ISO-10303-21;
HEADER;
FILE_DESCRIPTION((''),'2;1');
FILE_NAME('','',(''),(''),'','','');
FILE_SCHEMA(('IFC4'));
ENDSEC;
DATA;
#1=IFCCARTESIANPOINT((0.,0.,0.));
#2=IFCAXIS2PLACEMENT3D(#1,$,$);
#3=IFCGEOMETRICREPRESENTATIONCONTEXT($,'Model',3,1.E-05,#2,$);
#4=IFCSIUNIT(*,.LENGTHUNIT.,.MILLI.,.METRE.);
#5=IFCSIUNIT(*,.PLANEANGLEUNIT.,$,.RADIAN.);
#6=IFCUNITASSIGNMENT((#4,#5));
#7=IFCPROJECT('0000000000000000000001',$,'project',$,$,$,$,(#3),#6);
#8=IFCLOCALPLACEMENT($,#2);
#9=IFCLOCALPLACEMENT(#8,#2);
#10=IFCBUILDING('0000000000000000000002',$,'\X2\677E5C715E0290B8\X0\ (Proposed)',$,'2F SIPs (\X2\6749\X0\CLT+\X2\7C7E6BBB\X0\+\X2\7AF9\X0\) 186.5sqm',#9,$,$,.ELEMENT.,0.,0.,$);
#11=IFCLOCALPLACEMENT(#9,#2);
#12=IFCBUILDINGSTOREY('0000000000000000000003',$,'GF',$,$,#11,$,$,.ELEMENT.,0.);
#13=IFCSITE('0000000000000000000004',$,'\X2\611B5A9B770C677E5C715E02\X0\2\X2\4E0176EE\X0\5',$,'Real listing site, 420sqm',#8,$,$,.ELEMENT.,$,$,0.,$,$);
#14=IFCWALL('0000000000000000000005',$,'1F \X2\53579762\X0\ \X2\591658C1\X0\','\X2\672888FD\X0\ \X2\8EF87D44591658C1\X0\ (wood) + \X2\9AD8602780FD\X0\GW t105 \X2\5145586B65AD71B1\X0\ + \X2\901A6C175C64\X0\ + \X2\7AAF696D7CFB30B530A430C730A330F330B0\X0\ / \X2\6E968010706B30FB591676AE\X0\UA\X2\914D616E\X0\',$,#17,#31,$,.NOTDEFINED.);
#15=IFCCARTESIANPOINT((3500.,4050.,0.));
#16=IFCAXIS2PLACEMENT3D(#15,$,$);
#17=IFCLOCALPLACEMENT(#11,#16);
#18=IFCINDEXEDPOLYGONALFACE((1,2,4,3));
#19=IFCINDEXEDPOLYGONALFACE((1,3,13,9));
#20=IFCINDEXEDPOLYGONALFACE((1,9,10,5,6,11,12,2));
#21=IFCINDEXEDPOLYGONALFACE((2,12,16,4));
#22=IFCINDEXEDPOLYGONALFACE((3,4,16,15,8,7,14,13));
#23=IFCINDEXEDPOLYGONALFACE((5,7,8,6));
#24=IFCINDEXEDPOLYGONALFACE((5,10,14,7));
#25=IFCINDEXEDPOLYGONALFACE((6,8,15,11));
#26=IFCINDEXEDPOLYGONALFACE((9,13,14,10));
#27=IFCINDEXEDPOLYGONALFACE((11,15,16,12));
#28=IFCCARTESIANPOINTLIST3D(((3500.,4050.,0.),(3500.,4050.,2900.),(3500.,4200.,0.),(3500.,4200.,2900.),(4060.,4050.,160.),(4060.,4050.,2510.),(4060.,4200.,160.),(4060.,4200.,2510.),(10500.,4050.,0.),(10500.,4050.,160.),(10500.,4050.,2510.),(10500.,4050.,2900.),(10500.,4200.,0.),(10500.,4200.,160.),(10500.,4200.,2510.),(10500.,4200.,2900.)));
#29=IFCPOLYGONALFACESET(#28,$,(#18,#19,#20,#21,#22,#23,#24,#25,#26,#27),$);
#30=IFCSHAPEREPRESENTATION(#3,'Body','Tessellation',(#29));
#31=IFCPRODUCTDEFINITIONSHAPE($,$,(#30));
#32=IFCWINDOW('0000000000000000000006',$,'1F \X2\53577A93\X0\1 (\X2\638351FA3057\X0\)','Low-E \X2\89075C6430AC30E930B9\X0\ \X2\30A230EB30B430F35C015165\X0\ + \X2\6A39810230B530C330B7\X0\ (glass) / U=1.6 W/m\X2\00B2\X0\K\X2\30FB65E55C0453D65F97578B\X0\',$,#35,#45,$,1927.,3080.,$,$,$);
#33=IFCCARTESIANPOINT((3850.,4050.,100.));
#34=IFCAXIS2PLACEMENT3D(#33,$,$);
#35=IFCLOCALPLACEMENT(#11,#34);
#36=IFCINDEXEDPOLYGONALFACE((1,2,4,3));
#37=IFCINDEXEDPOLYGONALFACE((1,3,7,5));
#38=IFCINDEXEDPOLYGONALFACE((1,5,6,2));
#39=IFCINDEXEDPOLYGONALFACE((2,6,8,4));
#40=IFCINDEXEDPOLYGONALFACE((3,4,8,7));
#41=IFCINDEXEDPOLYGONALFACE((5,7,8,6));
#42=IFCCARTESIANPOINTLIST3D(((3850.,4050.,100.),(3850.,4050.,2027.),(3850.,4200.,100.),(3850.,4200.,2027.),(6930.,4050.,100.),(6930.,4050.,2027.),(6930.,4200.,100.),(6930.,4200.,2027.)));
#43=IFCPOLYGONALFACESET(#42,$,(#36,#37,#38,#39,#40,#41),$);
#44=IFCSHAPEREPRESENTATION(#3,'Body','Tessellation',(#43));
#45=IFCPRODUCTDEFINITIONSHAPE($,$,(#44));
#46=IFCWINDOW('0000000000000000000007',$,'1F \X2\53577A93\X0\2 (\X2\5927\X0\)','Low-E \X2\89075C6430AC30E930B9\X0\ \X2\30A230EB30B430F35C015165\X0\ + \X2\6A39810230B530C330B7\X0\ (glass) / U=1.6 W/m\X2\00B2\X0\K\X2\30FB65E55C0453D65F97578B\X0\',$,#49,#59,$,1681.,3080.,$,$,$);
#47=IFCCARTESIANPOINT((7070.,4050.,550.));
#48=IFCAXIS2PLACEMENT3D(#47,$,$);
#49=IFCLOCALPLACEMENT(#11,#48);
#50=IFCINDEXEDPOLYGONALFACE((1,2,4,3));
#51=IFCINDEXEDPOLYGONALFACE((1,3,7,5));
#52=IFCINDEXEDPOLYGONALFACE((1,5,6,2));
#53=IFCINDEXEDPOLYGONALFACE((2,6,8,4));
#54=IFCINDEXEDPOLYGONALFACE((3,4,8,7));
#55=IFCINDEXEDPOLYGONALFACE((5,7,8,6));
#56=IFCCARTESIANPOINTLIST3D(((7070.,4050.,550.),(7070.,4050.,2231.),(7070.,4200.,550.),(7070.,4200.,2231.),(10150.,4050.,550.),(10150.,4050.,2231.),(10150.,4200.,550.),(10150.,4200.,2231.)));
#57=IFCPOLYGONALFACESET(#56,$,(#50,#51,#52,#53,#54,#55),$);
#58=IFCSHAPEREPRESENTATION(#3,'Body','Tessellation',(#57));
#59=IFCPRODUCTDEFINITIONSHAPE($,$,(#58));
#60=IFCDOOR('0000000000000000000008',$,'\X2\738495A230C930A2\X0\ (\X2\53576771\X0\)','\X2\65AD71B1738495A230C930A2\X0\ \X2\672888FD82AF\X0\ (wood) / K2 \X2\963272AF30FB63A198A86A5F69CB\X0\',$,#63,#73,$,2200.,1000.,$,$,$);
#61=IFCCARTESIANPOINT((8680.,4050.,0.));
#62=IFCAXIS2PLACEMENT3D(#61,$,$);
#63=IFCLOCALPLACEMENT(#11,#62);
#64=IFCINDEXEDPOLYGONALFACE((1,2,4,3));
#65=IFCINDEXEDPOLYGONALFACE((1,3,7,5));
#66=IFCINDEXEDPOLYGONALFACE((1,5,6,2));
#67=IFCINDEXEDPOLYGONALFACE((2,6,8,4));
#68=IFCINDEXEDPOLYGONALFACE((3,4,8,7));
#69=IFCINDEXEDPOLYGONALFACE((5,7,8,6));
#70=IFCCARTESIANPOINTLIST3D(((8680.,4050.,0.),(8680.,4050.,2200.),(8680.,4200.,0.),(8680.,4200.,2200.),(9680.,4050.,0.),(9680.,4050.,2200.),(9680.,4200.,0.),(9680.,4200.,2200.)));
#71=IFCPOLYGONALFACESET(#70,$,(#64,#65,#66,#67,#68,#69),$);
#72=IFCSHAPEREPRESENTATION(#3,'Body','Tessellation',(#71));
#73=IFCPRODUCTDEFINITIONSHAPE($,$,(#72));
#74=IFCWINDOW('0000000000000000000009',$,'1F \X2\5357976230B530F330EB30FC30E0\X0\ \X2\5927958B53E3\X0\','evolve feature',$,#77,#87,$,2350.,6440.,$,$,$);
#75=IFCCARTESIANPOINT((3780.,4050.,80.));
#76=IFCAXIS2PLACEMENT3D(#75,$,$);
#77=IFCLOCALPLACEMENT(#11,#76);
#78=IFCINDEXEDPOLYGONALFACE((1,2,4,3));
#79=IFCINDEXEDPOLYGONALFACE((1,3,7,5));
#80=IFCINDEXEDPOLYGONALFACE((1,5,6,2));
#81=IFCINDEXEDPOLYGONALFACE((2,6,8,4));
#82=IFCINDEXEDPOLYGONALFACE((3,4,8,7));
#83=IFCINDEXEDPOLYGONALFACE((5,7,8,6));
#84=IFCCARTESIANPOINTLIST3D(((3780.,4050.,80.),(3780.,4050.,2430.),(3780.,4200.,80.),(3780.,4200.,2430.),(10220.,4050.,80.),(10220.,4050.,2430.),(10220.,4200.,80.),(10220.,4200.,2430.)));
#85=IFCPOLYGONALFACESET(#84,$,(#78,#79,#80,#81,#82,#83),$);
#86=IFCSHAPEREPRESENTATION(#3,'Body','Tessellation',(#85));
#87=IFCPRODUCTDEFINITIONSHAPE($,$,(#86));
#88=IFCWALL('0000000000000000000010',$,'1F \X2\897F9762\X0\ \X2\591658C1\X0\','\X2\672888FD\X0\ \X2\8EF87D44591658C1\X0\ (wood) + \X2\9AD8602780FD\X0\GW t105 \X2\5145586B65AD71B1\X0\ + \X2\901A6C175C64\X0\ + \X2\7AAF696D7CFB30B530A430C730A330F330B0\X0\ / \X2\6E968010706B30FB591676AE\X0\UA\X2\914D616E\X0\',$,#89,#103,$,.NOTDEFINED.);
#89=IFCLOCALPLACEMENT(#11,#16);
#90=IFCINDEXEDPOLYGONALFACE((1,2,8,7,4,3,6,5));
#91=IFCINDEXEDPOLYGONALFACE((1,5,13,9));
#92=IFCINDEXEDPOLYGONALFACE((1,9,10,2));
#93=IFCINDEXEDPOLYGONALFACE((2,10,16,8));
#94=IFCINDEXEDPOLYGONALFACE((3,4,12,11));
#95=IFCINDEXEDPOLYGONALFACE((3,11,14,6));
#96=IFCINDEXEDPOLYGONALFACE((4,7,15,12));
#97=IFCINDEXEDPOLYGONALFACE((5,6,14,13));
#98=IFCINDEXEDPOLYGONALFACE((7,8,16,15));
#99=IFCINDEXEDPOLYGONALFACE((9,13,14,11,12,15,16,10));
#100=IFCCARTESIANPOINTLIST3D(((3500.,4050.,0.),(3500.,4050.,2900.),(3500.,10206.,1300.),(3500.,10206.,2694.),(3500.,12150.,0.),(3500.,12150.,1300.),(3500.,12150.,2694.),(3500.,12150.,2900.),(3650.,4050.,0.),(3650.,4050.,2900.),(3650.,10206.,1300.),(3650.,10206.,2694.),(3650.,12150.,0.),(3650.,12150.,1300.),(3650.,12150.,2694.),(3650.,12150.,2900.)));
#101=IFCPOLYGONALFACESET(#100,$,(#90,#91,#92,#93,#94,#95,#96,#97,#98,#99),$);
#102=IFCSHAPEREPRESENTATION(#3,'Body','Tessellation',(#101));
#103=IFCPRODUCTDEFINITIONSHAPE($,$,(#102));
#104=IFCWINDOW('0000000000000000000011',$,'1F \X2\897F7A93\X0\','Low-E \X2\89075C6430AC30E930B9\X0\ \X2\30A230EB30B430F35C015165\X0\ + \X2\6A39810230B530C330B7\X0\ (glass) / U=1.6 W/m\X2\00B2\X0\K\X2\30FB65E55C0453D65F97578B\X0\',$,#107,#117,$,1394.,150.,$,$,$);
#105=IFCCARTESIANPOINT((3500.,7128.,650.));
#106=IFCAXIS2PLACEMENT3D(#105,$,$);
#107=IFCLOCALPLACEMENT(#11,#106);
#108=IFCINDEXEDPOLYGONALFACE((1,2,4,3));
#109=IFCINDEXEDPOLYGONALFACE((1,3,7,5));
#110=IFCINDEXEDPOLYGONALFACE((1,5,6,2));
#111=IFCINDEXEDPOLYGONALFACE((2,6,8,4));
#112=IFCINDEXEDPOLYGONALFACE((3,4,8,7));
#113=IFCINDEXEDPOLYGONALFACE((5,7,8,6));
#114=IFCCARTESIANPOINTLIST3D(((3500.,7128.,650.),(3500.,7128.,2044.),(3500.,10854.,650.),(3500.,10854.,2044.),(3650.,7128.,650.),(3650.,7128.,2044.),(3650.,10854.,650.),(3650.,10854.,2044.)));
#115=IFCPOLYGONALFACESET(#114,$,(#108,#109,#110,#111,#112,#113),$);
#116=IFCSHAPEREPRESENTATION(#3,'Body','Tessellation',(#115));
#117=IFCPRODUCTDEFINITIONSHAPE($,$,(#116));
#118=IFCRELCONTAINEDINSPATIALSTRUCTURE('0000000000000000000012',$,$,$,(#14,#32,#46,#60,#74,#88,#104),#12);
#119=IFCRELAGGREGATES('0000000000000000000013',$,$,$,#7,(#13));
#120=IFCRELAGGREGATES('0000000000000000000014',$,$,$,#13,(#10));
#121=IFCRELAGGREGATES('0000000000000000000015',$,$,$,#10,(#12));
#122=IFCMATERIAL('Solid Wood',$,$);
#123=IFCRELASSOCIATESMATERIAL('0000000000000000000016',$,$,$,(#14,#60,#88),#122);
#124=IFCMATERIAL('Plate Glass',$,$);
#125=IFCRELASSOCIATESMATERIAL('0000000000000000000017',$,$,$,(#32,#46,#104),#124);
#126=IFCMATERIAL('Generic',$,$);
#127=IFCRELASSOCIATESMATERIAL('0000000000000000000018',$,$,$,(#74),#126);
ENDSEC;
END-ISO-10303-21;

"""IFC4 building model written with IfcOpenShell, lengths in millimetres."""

from ifc_helpers import new_model, si_unit, frame, frame_2d, origin, place, context, project, spatial, rectangle, extrude, material, element, fill, save


model = new_model("IFC4")

# Units and contexts
model_context = context("Model", 3, precision=1e-05, world=origin())
ifc_project = project(units=[si_unit("LENGTHUNIT", "METRE", prefix="MILLI"), si_unit("PLANEANGLEUNIT", "RADIAN")], contexts=[model_context])

# Site, building, storey
site_placement = place(None, origin())
site = spatial("IfcSite", under=ifc_project, at=site_placement, Name="愛媛県松山市2丁目5", ObjectType="Real listing site, 420sqm", CompositionType="ELEMENT", RefElevation=0.0)
building_placement = place(site_placement, origin())
building = spatial("IfcBuilding", under=site, at=building_placement, Name="松山市邸 (Proposed)", ObjectType="2F SIPs (杉CLT+籾殻+竹) 186.5sqm", CompositionType="ELEMENT", ElevationOfRefHeight=0.0, ElevationOfTerrain=0.0)
storey_placement = place(building_placement, origin())
storey = spatial("IfcBuildingStorey", under=building, at=storey_placement, Name="GF", CompositionType="ELEMENT", Elevation=0.0)

# Shared definitions
ifc_material_1 = material(Name="Solid Wood")
ifc_material_2 = material(Name="Generic")

# Wall, openings, windows, door
wall_1_placement = place(storey_placement, frame((3500.0, 4050.0, 0.0)))
wall_1 = element("IfcWall", 1, at=wall_1_placement, inside=storey, material=ifc_material_1, Name="1F 南面 外壁", Description="木製 軸組外壁 (wood) + 高性能GW t105 充填断熱 + 通気層 + 窯業系サイディング / 準耐火・外皮UA配慮", PredefinedType="NOTDEFINED", context=model_context, shape_type="SweptSolid", body=[
    extrude(rectangle(XDim=7000.0, YDim=150.0, at=frame_2d((3500.0, 75.0))), frame((3500.0, 4050.0, 0.0)), (0.0, 0.0, 1.0), 2900.0),
])
opening_1_placement = place(storey_placement, frame((3850.0, 4050.0, 100.0)))
opening_1 = element("IfcOpeningElement", 2, at=opening_1_placement, cuts=wall_1, PredefinedType="NOTDEFINED", context=model_context, shape_type="SweptSolid", body=[
    extrude(rectangle(XDim=3080.0, YDim=150.0, at=frame_2d((1540.0, 75.0))), frame((3850.0, 4050.0, 100.0)), (0.0, 0.0, 1.0), 1927.0),
])
opening_2_placement = place(storey_placement, frame((7070.0, 4050.0, 550.0)))
opening_2 = element("IfcOpeningElement", 3, at=opening_2_placement, cuts=wall_1, PredefinedType="NOTDEFINED", context=model_context, shape_type="SweptSolid", body=[
    extrude(rectangle(XDim=3080.0, YDim=150.0, at=frame_2d((1540.0, 75.0))), frame((7070.0, 4050.0, 550.0)), (0.0, 0.0, 1.0), 1681.0),
])
opening_3_placement = place(storey_placement, frame((8680.0, 4050.0, 0.0)))
opening_3 = element("IfcOpeningElement", 4, at=opening_3_placement, cuts=wall_1, PredefinedType="NOTDEFINED", context=model_context, shape_type="SweptSolid", body=[
    extrude(rectangle(XDim=1000.0, YDim=150.0, at=frame_2d((500.0, 75.0))), frame((8680.0, 4050.0, 0.0)), (0.0, 0.0, 1.0), 2200.0),
])
opening_4_placement = place(storey_placement, frame((3780.0, 4050.0, 80.0)))
opening_4 = element("IfcOpeningElement", 5, at=opening_4_placement, cuts=wall_1, PredefinedType="NOTDEFINED", context=model_context, shape_type="SweptSolid", body=[
    extrude(rectangle(XDim=6440.0, YDim=150.0, at=frame_2d((3220.0, 75.0))), frame((3780.0, 4050.0, 80.0)), (0.0, 0.0, 1.0), 2350.0),
])
ifc_material_3 = material(Name="Plate Glass")
window_1_placement = place(storey_placement, frame((3850.0, 4050.0, 100.0)))
window_1 = element("IfcWindow", 6, at=window_1_placement, inside=storey, material=ifc_material_3, Name="1F 南窓1 (掃出し)", Description="Low-E 複層ガラス アルゴン封入 + 樹脂サッシ (glass) / U=1.6 W/m²K・日射取得型", OverallHeight=1927.0, OverallWidth=3080.0, context=model_context, shape_type="SweptSolid", body=[
    extrude(rectangle(XDim=3080.0, YDim=150.0, at=frame_2d((1540.0, 75.0))), frame((3850.0, 4050.0, 100.0)), (0.0, 0.0, 1.0), 1927.0),
])
fill(opening_1, window_1)
window_2_placement = place(storey_placement, frame((7070.0, 4050.0, 550.0)))
window_2 = element("IfcWindow", 7, at=window_2_placement, inside=storey, material=ifc_material_3, Name="1F 南窓2 (大)", Description="Low-E 複層ガラス アルゴン封入 + 樹脂サッシ (glass) / U=1.6 W/m²K・日射取得型", OverallHeight=1681.0, OverallWidth=3080.0, context=model_context, shape_type="SweptSolid", body=[
    extrude(rectangle(XDim=3080.0, YDim=150.0, at=frame_2d((1540.0, 75.0))), frame((7070.0, 4050.0, 550.0)), (0.0, 0.0, 1.0), 1681.0),
])
fill(opening_2, window_2)
door_placement = place(storey_placement, frame((8680.0, 4050.0, 0.0)))
door = element("IfcDoor", 8, at=door_placement, inside=storey, material=ifc_material_1, Name="玄関ドア (南東)", Description="断熱玄関ドア 木製芯 (wood) / K2 防犯・採風機構", OverallHeight=2200.0, OverallWidth=1000.0, context=model_context, shape_type="SweptSolid", body=[
    extrude(rectangle(XDim=1000.0, YDim=150.0, at=frame_2d((500.0, 75.0))), frame((8680.0, 4050.0, 0.0)), (0.0, 0.0, 1.0), 2200.0),
])
fill(opening_3, door)
window_3_placement = place(storey_placement, frame((3780.0, 4050.0, 80.0)))
window_3 = element("IfcWindow", 9, at=window_3_placement, inside=storey, material=ifc_material_2, Name="1F 南面サンルーム 大開口", Description="evolve feature", OverallHeight=2350.0, OverallWidth=6440.0, context=model_context, shape_type="SweptSolid", body=[
    extrude(rectangle(XDim=6440.0, YDim=150.0, at=frame_2d((3220.0, 75.0))), frame((3780.0, 4050.0, 80.0)), (0.0, 0.0, 1.0), 2350.0),
])
fill(opening_4, window_3)

# Wall, opening, window
wall_2_placement = place(storey_placement, frame((3500.0, 4050.0, 0.0)))
wall_2 = element("IfcWall", 10, at=wall_2_placement, inside=storey, material=ifc_material_1, Name="1F 西面 外壁", Description="木製 軸組外壁 (wood) + 高性能GW t105 充填断熱 + 通気層 + 窯業系サイディング / 準耐火・外皮UA配慮", PredefinedType="NOTDEFINED", context=model_context, shape_type="SweptSolid", body=[
    extrude(rectangle(XDim=150.0, YDim=8100.0, at=frame_2d((75.0, 4050.0))), frame((3500.0, 4050.0, 0.0)), (0.0, 0.0, 1.0), 2900.0),
])
opening_5_placement = place(storey_placement, frame((3500.0, 7128.0, 650.0)))
opening_5 = element("IfcOpeningElement", 11, at=opening_5_placement, cuts=wall_2, PredefinedType="NOTDEFINED", context=model_context, shape_type="SweptSolid", body=[
    extrude(rectangle(XDim=150.0, YDim=3726.0, at=frame_2d((75.0, 1863.0))), frame((3500.0, 7128.0, 650.0)), (0.0, 0.0, 1.0), 1394.0),
])
window_4_placement = place(storey_placement, frame((3500.0, 7128.0, 650.0)))
window_4 = element("IfcWindow", 12, at=window_4_placement, inside=storey, material=ifc_material_3, Name="1F 西窓", Description="Low-E 複層ガラス アルゴン封入 + 樹脂サッシ (glass) / U=1.6 W/m²K・日射取得型", OverallHeight=1394.0, OverallWidth=150.0, context=model_context, shape_type="SweptSolid", body=[
    extrude(rectangle(XDim=150.0, YDim=3726.0, at=frame_2d((75.0, 1863.0))), frame((3500.0, 7128.0, 650.0)), (0.0, 0.0, 1.0), 1394.0),
])
fill(opening_5, window_4)

save(model, "model.ifc")
